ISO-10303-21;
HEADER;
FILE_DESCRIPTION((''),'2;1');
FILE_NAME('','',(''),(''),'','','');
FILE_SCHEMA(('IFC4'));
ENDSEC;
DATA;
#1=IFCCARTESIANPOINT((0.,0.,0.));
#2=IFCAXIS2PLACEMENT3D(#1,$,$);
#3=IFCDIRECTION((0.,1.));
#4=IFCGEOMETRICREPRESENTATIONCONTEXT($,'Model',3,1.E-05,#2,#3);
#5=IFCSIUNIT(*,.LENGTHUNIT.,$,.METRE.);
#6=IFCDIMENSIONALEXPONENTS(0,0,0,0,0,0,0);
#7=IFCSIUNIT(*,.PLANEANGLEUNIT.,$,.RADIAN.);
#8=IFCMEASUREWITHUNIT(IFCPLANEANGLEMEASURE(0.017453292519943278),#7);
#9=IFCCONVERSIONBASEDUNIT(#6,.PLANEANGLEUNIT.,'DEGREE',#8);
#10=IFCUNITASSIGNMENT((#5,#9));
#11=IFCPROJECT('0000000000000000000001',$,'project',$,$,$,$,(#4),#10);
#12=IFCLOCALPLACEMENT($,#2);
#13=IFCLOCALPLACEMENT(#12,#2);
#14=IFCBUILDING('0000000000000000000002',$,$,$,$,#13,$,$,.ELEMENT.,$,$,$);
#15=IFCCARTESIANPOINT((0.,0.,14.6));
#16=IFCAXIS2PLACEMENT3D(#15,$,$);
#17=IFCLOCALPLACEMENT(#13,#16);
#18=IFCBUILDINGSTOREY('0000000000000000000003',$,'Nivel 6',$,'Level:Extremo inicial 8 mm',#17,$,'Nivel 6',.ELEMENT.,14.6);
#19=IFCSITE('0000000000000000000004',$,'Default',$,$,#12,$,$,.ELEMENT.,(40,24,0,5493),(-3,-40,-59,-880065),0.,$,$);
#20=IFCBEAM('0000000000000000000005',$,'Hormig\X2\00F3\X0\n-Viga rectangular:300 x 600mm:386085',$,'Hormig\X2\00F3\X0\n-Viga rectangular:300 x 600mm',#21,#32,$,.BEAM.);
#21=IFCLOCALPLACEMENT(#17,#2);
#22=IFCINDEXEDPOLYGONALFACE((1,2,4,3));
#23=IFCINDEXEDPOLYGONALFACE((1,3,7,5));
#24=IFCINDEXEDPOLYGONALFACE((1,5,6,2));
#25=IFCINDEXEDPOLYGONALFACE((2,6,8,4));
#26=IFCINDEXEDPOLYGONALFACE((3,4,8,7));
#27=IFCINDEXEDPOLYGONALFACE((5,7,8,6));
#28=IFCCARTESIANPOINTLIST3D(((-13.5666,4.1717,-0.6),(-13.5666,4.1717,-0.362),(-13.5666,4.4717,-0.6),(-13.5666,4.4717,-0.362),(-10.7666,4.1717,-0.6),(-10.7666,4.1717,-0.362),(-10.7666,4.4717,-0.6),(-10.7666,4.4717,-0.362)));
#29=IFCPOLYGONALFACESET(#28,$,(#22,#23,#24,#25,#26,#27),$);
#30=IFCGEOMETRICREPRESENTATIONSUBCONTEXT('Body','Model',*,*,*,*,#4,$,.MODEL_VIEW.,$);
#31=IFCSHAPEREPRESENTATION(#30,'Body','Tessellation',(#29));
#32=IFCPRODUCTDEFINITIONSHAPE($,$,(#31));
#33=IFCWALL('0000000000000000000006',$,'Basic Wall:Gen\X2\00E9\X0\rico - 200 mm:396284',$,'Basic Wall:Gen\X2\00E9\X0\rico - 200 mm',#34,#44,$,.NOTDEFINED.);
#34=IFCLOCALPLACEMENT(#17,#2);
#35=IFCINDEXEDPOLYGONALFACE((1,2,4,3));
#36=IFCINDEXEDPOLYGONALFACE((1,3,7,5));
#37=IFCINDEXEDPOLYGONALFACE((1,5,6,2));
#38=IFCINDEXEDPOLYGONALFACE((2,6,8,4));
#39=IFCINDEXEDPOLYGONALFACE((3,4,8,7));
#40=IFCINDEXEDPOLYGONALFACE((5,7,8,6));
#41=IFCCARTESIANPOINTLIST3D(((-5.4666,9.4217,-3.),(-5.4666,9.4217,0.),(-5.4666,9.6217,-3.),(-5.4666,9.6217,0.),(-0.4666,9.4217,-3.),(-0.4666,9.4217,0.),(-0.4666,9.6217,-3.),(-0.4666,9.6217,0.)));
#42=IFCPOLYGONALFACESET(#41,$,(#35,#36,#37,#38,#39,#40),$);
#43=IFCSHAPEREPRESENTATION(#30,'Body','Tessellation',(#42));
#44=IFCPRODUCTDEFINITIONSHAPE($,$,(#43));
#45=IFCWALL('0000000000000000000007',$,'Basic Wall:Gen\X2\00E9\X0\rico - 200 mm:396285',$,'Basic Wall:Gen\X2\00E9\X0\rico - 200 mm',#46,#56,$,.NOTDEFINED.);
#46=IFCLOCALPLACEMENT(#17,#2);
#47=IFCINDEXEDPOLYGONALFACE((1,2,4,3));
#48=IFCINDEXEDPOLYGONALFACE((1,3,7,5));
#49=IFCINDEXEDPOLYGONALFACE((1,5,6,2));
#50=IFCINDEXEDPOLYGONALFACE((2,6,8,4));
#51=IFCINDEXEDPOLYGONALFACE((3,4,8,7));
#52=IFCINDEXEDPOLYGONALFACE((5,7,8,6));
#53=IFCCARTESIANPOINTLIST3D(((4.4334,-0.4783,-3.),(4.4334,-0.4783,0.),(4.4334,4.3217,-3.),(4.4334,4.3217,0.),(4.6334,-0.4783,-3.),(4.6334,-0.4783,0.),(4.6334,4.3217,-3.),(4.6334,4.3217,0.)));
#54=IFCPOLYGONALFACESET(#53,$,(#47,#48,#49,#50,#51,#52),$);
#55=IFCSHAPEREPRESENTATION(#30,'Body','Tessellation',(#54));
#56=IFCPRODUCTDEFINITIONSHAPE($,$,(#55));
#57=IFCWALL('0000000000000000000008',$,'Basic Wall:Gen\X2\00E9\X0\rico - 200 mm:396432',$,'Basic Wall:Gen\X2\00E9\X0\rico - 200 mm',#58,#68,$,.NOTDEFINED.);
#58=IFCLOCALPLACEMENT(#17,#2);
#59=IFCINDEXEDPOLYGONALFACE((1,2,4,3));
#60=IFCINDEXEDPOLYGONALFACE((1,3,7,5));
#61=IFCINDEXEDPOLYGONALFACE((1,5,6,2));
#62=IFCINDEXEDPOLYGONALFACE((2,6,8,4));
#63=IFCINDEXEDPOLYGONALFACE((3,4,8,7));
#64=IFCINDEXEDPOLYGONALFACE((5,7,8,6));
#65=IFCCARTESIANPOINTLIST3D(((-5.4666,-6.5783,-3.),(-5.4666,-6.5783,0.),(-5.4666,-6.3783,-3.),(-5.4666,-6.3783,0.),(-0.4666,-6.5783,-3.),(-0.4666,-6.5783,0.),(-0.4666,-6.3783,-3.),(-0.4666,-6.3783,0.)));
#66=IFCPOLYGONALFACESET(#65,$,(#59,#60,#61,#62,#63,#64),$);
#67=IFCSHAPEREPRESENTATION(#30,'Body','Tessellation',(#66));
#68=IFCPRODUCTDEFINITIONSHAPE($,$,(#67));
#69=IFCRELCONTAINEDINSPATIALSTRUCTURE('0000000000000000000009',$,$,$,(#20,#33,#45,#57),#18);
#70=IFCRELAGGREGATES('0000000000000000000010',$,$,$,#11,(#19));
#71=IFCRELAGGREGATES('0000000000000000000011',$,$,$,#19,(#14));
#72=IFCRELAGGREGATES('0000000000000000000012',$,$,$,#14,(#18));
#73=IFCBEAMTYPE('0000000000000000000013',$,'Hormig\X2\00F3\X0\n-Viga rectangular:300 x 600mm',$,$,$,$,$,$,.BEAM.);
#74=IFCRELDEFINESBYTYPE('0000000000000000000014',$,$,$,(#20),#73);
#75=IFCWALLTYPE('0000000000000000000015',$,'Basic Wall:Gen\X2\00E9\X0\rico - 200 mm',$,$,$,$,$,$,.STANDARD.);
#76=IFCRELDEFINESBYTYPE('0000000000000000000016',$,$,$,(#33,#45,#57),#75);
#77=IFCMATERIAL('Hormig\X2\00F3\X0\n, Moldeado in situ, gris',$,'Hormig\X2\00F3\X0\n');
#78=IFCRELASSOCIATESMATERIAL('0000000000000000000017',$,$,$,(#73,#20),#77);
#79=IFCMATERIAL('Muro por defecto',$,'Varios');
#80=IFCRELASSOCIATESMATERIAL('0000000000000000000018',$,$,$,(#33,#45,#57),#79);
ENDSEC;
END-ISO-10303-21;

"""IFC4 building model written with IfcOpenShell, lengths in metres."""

from ifc_helpers import new_model, entity, si_unit, converted_unit, direction, frame, origin, place, context, subcontext, project, spatial, indexed_curve, outline, extrude, source, transform, mapped, material, type_object, type_shapes, element, save


model = new_model("IFC4")

# Units and contexts
model_context = context("Model", 3, precision=1e-05, world=origin(), true_north=direction((0.0, 1.0)))
body_context = subcontext(model_context, "Body", "Model", "MODEL_VIEW")
ifc_project = project(units=[si_unit("LENGTHUNIT", "METRE"), converted_unit("PLANEANGLEUNIT", "DEGREE", entity("IfcPlaneAngleMeasure", 0.017453292519943278), si_unit("PLANEANGLEUNIT", "RADIAN"), dimensions=[0, 0, 0, 0, 0, 0, 0])], contexts=[model_context])

# Site, building, storey
site_placement = place(None, origin())
site = spatial("IfcSite", under=ifc_project, at=site_placement, Name="Default", CompositionType="ELEMENT", RefLatitude=(40, 24, 0, 5493), RefLongitude=(-3, -40, -59, -880065), RefElevation=0.0)
building_placement = place(site_placement, origin())
building = spatial("IfcBuilding", under=site, at=building_placement, CompositionType="ELEMENT")
storey_placement = place(building_placement, frame((0.0, 0.0, 14.6)))
storey = spatial("IfcBuildingStorey", under=building, at=storey_placement, Name="Nivel 6", ObjectType="Level:Extremo inicial 8 mm", LongName="Nivel 6", CompositionType="ELEMENT", Elevation=14.6)

# Shared definitions
ifc_material_1 = material(Name="Hormigón, Moldeado in situ, gris", Category="Hormigón")

# Beam
beam_type_1 = type_object("IfcBeamType", Name="Hormigón-Viga rectangular:300 x 600mm", PredefinedType="BEAM", material=ifc_material_1)
shared_shape_1 = source(origin(), body_context, "Body", "SweptSolid", [
    extrude(outline(indexed_curve([(-0.119, -0.15), (0.119, -0.15), (0.119, 0.15), (-0.119, 0.15), (-0.119, -0.15)], self_intersect=False)), frame((-10.7666, 4.3217, 14.119), z_axis=(-1.0, 0.0, 0.0), x_axis=(0.0, 0.0, -1.0)), (0.0, 0.0, 1.0), 2.8),
])
type_shapes(beam_type_1, [shared_shape_1])
beam_1_placement = place(storey_placement, frame((0.0, 0.0, -14.6)))
element("IfcBeam", 1, at=beam_1_placement, inside=storey, type_object=beam_type_1, material=ifc_material_1, Name="Hormigón-Viga rectangular:300 x 600mm:386085", ObjectType="Hormigón-Viga rectangular:300 x 600mm", PredefinedType="BEAM", context=body_context, shape_type="MappedRepresentation", body=[
    mapped(shared_shape_1, transform((0.0, 0.0, 0.0), scale=1.0)),
])

# Walls
ifc_material_2 = material(Name="Muro por defecto", Category="Varios")
wall_type = type_object("IfcWallType", Name="Basic Wall:Genérico - 200 mm", PredefinedType="STANDARD")
wall_1_placement = place(storey_placement, frame((-5.4666, 9.5217, -3.0)))
element("IfcWall", 2, at=wall_1_placement, inside=storey, type_object=wall_type, material=ifc_material_2, Name="Basic Wall:Genérico - 200 mm:396284", ObjectType="Basic Wall:Genérico - 200 mm", PredefinedType="NOTDEFINED", context=body_context, shape_type="SweptSolid", body=[
    extrude(outline(indexed_curve([(5.0, 0.1), (0.0, 0.1), (0.0, -0.1), (5.0, -0.1), (5.0, 0.1)], self_intersect=False)), origin(), (0.0, 0.0, 1.0), 3.0),
])
wall_2_placement = place(storey_placement, frame((4.5334, 4.3217, -3.0), z_axis=(0.0, 0.0, 1.0), x_axis=(0.0, -1.0, 0.0)))
element("IfcWall", 3, at=wall_2_placement, inside=storey, type_object=wall_type, material=ifc_material_2, Name="Basic Wall:Genérico - 200 mm:396285", ObjectType="Basic Wall:Genérico - 200 mm", PredefinedType="NOTDEFINED", context=body_context, shape_type="SweptSolid", body=[
    extrude(outline(indexed_curve([(4.8, 0.1), (0.0, 0.1), (0.0, -0.1), (4.8, -0.1), (4.8, 0.1)], self_intersect=False)), origin(), (0.0, 0.0, 1.0), 3.0),
])
wall_3_placement = place(storey_placement, frame((-5.4666, -6.4783, -3.0)))
element("IfcWall", 4, at=wall_3_placement, inside=storey, type_object=wall_type, material=ifc_material_2, Name="Basic Wall:Genérico - 200 mm:396432", ObjectType="Basic Wall:Genérico - 200 mm", PredefinedType="NOTDEFINED", context=body_context, shape_type="SweptSolid", body=[
    extrude(outline(indexed_curve([(5.0, 0.1), (0.0, 0.1), (0.0, -0.1), (5.0, -0.1), (5.0, 0.1)], self_intersect=False)), origin(), (0.0, 0.0, 1.0), 3.0),
])

save(model, "model.ifc")
